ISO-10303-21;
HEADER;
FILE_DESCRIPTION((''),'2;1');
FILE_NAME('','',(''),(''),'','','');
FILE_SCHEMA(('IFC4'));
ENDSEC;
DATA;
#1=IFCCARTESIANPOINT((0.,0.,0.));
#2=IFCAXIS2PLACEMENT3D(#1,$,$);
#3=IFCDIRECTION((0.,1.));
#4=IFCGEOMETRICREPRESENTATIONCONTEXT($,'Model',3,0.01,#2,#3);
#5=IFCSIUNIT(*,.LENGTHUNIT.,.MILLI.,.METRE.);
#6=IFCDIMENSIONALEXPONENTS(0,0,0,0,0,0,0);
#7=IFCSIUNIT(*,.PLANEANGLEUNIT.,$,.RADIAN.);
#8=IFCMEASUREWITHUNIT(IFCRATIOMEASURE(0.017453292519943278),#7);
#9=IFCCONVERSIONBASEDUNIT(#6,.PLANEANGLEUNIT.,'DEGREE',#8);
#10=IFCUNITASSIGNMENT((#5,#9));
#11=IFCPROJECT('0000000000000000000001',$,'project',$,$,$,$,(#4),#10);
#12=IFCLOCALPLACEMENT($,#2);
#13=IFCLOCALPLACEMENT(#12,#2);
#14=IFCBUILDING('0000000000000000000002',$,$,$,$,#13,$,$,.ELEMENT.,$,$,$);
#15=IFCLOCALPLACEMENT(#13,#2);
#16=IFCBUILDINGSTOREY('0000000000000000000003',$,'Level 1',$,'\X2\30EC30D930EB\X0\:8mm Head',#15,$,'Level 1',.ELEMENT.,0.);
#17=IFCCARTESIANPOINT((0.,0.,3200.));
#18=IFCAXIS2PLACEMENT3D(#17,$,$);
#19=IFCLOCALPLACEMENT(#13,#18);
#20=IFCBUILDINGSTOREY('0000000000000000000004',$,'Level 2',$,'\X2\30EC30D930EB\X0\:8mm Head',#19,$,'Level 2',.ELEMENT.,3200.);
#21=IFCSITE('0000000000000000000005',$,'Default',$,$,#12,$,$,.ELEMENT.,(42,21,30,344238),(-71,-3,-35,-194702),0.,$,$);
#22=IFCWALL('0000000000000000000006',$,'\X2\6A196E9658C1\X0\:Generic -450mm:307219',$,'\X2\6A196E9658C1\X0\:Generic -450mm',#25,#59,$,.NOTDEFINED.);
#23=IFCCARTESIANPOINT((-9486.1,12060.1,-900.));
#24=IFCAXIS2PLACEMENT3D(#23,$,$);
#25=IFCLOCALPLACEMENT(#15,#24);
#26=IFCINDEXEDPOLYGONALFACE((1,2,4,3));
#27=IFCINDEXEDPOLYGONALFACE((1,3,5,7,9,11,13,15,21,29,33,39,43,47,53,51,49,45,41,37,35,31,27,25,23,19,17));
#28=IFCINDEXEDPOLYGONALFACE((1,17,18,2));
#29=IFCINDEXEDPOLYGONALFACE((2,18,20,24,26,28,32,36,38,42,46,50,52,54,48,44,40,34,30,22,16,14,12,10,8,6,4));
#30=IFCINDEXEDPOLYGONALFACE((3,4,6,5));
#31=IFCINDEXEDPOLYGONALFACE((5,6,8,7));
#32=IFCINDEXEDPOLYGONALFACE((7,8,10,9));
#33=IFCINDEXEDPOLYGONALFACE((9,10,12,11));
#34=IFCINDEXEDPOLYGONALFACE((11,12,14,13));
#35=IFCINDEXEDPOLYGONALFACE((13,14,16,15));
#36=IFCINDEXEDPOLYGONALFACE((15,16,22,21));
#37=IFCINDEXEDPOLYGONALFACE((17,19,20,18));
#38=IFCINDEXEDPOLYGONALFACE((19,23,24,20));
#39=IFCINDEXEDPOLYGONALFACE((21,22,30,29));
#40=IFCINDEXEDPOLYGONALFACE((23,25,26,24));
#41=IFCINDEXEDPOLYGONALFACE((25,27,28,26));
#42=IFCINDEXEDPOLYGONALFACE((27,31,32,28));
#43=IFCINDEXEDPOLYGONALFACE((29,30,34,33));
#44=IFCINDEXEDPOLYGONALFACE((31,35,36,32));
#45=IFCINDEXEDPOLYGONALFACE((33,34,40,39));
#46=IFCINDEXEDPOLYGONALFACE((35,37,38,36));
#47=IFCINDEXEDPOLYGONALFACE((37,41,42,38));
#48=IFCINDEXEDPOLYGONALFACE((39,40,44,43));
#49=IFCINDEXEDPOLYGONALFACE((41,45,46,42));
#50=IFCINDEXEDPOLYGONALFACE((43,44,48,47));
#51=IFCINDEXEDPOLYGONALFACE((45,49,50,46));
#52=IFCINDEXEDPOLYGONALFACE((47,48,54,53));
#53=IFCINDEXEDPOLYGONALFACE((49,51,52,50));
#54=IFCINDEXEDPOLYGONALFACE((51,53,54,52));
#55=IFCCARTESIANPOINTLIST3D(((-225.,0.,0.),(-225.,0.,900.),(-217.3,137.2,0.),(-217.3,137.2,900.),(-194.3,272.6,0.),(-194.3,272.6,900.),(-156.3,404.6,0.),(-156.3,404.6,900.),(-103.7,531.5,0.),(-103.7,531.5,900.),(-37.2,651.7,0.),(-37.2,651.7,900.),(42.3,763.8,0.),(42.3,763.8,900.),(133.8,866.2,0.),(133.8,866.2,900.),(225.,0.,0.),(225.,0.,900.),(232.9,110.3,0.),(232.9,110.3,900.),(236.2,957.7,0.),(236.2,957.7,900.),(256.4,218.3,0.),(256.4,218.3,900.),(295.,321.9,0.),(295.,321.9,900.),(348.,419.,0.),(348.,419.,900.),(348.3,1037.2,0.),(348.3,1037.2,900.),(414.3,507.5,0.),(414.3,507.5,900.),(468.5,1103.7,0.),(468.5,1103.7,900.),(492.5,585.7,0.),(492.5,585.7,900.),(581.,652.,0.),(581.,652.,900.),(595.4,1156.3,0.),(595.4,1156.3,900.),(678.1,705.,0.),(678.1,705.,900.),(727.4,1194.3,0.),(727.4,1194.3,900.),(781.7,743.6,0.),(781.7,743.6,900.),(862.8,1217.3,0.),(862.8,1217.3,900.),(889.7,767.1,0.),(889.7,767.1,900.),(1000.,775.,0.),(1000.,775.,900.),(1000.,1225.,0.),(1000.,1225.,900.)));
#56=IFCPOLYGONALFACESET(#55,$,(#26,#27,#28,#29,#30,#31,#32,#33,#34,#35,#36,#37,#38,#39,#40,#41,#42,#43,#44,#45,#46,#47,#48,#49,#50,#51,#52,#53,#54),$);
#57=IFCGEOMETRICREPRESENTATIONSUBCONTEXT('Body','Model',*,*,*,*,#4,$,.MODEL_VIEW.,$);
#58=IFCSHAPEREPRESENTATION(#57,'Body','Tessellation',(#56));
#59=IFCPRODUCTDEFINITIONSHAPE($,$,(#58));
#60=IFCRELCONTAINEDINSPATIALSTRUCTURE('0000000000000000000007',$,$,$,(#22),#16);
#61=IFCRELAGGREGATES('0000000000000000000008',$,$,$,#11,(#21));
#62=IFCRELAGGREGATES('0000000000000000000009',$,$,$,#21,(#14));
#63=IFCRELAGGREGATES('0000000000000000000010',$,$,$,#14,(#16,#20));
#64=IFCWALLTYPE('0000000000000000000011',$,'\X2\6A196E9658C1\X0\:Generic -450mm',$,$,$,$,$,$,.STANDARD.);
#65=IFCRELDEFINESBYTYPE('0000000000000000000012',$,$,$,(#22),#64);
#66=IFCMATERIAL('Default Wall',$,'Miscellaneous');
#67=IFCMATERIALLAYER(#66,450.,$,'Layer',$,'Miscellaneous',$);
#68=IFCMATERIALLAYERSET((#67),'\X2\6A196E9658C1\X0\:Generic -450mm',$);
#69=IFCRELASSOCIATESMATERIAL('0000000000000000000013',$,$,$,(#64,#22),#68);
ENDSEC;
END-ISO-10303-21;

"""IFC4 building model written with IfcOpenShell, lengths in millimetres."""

from ifc_helpers import new_model, entity, si_unit, converted_unit, direction, frame, frame_2d, origin, place, context, subcontext, project, spatial, polyline, circle_curve, parameter, trimmed, segment, composite_curve, outline, extrude, material, layer, layer_set, layer_usage, type_object, element, save


model = new_model("IFC4")

# Units and contexts
model_context = context("Model", 3, precision=0.01, world=origin(), true_north=direction((0.0, 1.0)))
body_context = subcontext(model_context, "Body", "Model", "MODEL_VIEW")
ifc_project = project(units=[si_unit("LENGTHUNIT", "METRE", prefix="MILLI"), converted_unit("PLANEANGLEUNIT", "DEGREE", entity("IfcRatioMeasure", 0.017453292519943278), si_unit("PLANEANGLEUNIT", "RADIAN"), dimensions=[0, 0, 0, 0, 0, 0, 0])], contexts=[model_context])

# Site, building, storey
site_placement = place(None, origin())
site = spatial("IfcSite", under=ifc_project, at=site_placement, Name="Default", CompositionType="ELEMENT", RefLatitude=(42, 21, 30, 344238), RefLongitude=(-71, -3, -35, -194702), RefElevation=0.0)
building_placement = place(site_placement, origin())
building = spatial("IfcBuilding", under=site, at=building_placement, CompositionType="ELEMENT")
storey_1_placement = place(building_placement, origin())
storey_1 = spatial("IfcBuildingStorey", under=building, at=storey_1_placement, Name="Level 1", ObjectType="レベル:8mm Head", LongName="Level 1", CompositionType="ELEMENT", Elevation=0.0)

# Shared definitions
ifc_material_1 = material(Name="Default Wall", Category="Miscellaneous")
ifc_layer_1 = layer(ifc_material_1, 450.0, Name="Layer", Category="Miscellaneous")
ifc_layer_set_1 = layer_set([ifc_layer_1], Name="標準壁:Generic -450mm")
wall_type = type_object("IfcWallType", Name="標準壁:Generic -450mm", PredefinedType="STANDARD", material=ifc_layer_set_1)

# Shared definitions
storey_2_placement = place(building_placement, frame((0.0, 0.0, 3200.0)))
storey_2 = spatial("IfcBuildingStorey", under=building, at=storey_2_placement, Name="Level 2", ObjectType="レベル:8mm Head", LongName="Level 2", CompositionType="ELEMENT", Elevation=3200.0)

# Wall
ifc_layer_usage_1 = layer_usage(ifc_layer_set_1, "AXIS2", "POSITIVE", -225.0)
wall_1_placement = place(storey_1_placement, frame((-9486.1, 12060.1, -900.0)))
element("IfcWall", 1, at=wall_1_placement, inside=storey_1, type_object=wall_type, material=ifc_layer_usage_1, Name="標準壁:Generic -450mm:307219", ObjectType="標準壁:Generic -450mm", PredefinedType="NOTDEFINED", context=body_context, shape_type="SweptSolid", body=[
    extrude(outline(composite_curve([segment(trimmed(circle_curve(frame_2d((1000.0, 0.0), x_axis=(1.0, 0.0)), 1225.0), [parameter(90.0)], [parameter(180.0)], True, "PARAMETER"), True, "CONTINUOUS"), segment(polyline([(-225.0, 0.0), (225.0, 0.0)]), True, "CONTINUOUS"), segment(trimmed(circle_curve(frame_2d((1000.0, 0.0), x_axis=(1.0, 0.0)), 775.0), [parameter(90.0)], [parameter(180.0)], True, "PARAMETER"), False, "CONTINUOUS"), segment(polyline([(1000.0, 775.0), (1000.0, 1225.0)]), True, "CONTINUOUS")], self_intersect=False)), origin(), (0.0, 0.0, 1.0), 900.0),
])

save(model, "model.ifc")
